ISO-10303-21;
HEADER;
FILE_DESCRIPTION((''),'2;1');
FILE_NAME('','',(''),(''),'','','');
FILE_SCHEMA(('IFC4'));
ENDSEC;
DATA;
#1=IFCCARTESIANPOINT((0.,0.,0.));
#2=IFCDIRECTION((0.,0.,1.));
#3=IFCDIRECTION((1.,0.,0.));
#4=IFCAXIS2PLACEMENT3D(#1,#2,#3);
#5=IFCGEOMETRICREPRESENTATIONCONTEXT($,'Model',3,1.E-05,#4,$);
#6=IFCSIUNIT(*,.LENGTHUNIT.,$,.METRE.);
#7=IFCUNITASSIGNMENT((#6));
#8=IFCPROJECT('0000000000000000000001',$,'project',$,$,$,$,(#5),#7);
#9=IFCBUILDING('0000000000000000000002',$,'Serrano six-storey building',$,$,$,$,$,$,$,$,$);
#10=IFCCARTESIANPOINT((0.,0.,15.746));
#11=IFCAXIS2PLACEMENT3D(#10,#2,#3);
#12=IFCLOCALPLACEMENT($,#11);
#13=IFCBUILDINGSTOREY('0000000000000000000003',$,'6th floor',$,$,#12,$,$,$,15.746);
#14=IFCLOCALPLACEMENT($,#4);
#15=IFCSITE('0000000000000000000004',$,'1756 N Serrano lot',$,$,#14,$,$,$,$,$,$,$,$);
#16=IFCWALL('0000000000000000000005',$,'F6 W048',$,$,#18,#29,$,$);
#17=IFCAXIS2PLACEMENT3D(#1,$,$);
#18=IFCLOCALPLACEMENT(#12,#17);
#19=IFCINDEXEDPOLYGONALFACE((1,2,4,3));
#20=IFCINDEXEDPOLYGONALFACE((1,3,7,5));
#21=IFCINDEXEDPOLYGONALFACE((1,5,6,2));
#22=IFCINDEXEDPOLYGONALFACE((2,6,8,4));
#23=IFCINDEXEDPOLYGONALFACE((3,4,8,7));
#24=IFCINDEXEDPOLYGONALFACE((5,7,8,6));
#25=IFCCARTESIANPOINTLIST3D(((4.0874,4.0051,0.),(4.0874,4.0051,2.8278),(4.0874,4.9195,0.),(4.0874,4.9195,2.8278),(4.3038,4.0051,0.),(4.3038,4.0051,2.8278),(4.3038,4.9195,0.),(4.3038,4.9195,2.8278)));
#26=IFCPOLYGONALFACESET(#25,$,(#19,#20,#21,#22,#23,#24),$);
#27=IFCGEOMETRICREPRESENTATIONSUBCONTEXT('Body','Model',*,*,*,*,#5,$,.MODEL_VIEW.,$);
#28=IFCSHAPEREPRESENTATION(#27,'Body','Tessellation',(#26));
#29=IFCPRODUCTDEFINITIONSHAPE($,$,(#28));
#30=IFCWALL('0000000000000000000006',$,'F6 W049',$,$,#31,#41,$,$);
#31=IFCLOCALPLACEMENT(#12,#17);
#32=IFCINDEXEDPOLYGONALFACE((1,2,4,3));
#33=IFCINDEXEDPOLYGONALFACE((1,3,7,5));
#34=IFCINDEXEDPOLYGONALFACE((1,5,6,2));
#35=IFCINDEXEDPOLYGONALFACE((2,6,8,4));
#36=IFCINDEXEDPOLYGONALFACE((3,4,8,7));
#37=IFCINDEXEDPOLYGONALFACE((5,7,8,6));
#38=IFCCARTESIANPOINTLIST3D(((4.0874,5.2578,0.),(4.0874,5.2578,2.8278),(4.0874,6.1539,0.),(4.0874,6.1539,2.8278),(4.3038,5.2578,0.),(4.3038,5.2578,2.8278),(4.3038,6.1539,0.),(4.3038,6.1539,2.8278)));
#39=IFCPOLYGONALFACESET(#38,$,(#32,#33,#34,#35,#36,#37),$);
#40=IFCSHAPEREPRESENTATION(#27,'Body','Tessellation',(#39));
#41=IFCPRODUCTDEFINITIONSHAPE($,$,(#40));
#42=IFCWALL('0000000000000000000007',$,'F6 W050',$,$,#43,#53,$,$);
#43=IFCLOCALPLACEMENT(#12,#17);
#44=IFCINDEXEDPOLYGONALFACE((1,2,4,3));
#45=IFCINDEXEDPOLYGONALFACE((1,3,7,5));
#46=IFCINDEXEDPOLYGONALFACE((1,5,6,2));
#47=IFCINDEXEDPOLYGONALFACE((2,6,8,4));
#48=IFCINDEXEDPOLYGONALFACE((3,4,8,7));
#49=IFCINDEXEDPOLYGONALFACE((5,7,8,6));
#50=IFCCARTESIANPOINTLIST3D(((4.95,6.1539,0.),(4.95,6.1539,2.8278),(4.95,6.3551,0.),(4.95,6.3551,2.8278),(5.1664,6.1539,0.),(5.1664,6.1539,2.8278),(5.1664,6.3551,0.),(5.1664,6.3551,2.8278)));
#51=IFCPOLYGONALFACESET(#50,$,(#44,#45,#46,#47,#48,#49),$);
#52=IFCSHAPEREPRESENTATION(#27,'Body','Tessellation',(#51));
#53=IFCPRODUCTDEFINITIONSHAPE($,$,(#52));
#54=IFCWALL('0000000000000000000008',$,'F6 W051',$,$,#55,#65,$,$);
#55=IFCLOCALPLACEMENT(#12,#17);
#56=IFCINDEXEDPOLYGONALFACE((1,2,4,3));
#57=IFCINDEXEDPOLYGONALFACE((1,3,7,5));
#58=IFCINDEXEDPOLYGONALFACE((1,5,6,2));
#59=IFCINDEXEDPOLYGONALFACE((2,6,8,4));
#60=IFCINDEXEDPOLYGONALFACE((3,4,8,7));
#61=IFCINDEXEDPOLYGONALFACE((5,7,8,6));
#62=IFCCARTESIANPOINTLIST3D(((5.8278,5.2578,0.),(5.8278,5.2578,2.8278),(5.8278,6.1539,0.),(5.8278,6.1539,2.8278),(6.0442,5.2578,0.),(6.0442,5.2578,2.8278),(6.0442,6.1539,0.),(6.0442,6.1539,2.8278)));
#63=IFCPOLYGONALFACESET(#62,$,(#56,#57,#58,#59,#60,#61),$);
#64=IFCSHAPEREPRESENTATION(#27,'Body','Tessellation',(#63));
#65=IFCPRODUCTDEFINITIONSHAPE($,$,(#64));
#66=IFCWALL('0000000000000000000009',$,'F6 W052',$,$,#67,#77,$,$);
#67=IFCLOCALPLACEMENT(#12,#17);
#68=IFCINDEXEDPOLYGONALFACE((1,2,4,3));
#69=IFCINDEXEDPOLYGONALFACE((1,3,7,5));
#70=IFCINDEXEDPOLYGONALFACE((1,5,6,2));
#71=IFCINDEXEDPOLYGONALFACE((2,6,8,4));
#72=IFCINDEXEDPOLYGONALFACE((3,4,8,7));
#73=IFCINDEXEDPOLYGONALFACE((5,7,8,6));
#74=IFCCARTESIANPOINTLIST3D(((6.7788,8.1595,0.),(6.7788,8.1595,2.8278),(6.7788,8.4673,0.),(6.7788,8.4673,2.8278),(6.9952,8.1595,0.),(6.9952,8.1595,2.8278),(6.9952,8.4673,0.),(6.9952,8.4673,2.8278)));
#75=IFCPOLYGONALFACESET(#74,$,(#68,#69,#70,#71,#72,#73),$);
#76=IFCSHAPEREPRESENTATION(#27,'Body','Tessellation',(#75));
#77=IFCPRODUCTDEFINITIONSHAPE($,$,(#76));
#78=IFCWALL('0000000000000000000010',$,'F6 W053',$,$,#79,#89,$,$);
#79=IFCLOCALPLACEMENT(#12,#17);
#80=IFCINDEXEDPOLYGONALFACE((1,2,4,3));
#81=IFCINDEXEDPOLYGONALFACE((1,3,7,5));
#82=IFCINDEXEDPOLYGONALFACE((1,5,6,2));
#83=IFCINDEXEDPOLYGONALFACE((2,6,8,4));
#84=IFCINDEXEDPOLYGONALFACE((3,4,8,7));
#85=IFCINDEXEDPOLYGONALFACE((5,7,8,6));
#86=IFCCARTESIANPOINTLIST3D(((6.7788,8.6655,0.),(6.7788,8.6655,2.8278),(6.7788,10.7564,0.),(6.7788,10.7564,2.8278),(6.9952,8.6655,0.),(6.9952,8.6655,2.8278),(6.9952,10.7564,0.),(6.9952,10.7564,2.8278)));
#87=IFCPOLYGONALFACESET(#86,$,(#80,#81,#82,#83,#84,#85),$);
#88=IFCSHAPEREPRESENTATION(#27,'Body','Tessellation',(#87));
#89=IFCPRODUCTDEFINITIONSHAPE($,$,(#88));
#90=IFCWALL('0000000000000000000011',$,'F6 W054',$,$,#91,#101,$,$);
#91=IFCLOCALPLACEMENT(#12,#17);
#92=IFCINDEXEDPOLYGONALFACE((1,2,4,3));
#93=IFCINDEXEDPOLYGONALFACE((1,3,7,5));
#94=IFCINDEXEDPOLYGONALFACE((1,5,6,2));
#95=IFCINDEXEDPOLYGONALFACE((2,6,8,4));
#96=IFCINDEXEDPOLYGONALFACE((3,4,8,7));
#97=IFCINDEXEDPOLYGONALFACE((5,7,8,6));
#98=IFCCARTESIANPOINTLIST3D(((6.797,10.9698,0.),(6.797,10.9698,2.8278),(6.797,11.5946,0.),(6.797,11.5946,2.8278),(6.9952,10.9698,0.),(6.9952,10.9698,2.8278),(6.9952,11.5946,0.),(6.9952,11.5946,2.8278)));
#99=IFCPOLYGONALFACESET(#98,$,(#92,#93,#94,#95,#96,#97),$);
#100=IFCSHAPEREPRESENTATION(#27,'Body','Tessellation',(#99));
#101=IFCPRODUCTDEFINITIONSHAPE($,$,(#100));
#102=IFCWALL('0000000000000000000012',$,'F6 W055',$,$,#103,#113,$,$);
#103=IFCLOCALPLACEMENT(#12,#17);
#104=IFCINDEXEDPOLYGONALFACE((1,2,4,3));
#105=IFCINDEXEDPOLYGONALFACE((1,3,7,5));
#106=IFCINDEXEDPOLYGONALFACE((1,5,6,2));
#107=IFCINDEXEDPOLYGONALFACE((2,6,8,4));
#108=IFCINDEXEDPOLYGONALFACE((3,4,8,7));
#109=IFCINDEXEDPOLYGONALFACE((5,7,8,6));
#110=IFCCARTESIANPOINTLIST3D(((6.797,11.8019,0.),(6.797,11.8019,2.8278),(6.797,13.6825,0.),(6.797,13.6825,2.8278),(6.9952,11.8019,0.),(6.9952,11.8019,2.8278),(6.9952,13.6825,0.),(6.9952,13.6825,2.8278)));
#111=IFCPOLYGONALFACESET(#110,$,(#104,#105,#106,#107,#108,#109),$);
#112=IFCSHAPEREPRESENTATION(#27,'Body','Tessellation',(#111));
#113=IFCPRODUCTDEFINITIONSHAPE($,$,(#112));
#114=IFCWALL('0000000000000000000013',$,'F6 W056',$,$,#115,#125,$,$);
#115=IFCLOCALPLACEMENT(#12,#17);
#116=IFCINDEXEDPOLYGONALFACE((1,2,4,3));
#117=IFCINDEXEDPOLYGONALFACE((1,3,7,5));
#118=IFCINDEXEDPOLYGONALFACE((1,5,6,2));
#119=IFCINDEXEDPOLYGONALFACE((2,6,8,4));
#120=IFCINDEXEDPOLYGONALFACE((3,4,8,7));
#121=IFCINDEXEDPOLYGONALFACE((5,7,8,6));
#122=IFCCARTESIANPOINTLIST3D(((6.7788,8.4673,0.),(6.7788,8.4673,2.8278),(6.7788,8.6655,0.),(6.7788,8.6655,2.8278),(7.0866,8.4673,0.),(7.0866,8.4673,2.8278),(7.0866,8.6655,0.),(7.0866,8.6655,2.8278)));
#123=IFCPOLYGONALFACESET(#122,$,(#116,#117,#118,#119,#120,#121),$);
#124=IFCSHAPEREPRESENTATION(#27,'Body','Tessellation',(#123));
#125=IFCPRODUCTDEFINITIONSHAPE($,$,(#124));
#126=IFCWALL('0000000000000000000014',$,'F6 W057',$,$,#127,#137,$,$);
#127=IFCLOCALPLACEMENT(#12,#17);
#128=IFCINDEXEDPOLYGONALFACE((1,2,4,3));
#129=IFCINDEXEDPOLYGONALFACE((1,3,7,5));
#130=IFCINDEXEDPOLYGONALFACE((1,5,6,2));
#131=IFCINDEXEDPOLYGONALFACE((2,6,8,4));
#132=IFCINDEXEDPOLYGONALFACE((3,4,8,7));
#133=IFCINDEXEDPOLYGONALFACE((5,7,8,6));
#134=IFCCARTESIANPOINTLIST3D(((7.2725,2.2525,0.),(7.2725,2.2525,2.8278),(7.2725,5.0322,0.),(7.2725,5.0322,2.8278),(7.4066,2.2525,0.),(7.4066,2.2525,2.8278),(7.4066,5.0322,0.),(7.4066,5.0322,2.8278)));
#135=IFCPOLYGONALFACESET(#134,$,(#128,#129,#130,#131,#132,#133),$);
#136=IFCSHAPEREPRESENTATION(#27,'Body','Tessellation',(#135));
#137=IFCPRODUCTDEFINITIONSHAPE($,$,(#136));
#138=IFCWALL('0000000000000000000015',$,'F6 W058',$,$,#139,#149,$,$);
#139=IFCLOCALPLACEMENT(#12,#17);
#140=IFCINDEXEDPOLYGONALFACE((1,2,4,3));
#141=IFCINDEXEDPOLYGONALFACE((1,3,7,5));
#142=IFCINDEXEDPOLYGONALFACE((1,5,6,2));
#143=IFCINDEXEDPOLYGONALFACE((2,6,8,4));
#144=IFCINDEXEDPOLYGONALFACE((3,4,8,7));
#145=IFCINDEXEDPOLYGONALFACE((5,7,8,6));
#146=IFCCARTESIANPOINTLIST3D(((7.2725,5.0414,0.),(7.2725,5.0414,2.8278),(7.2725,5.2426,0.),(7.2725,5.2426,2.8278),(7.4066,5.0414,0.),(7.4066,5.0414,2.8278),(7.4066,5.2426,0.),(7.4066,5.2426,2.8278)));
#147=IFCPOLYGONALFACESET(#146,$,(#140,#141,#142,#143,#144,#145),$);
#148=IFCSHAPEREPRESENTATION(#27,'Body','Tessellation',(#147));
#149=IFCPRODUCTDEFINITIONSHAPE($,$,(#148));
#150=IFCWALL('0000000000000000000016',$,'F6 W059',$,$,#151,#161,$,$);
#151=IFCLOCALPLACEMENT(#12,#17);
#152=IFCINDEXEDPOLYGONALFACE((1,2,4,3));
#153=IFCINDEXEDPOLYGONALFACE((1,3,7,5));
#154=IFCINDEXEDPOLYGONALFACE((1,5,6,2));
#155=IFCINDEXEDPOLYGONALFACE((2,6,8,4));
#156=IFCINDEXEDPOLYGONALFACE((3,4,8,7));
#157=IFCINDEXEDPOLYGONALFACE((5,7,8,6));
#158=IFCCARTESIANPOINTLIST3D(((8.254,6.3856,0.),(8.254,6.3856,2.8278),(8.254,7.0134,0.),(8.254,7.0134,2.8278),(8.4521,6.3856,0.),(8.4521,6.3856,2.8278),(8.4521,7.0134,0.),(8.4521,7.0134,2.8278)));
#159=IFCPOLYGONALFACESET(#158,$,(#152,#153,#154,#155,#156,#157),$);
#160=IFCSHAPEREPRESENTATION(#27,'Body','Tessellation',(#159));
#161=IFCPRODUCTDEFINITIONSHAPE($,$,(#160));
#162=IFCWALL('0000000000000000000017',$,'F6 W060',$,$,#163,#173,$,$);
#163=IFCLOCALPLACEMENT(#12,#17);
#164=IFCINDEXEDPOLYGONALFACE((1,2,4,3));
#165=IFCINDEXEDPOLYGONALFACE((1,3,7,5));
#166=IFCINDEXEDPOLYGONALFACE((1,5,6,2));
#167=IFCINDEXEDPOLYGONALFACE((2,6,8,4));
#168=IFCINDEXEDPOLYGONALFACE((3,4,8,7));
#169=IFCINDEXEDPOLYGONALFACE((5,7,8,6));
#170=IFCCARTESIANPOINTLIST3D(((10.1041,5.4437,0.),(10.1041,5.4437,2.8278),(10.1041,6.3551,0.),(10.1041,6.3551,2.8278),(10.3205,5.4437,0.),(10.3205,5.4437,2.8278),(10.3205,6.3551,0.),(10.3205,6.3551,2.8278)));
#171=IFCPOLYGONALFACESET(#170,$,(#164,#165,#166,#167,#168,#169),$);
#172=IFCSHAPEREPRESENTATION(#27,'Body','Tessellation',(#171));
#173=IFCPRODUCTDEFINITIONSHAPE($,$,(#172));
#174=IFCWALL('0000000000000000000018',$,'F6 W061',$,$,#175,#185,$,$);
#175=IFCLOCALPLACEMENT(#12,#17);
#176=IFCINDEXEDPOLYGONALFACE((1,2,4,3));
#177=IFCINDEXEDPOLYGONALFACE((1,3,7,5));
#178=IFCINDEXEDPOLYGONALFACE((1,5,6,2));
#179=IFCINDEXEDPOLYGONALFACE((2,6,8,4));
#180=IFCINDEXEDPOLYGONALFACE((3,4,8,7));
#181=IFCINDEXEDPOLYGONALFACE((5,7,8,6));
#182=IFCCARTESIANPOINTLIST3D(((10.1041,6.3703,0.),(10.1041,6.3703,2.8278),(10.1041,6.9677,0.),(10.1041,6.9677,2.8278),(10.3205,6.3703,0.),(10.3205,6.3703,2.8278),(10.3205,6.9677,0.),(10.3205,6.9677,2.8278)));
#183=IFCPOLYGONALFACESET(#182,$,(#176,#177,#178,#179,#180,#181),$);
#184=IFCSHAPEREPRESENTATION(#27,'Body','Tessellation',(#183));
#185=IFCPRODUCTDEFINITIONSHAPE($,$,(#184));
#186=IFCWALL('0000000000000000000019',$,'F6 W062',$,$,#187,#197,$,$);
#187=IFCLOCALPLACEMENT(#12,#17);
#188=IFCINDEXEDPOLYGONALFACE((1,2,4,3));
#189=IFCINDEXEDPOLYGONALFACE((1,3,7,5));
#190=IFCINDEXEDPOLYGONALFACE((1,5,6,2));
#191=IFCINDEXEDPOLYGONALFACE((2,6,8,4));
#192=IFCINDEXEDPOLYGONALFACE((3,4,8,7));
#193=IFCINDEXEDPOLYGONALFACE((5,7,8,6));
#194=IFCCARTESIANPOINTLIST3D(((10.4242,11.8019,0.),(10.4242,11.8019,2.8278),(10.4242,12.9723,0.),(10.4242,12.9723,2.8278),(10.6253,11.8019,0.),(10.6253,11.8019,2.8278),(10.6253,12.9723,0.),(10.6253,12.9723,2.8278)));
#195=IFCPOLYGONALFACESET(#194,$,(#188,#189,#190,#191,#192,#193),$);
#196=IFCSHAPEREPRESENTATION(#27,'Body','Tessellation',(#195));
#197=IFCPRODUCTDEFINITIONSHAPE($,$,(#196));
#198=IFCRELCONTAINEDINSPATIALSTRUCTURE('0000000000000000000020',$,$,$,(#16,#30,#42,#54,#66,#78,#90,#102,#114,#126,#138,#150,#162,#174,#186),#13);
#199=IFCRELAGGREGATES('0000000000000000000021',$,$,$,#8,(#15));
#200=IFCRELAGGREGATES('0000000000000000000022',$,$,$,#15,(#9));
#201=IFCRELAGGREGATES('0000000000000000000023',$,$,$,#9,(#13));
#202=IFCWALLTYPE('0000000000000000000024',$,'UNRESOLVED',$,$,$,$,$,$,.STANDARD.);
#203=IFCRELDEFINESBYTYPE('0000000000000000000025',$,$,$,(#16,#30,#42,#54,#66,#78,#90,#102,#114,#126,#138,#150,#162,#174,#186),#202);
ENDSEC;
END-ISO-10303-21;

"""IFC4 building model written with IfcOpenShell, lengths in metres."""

from ifc_helpers import new_model, si_unit, frame, origin_with_axes, place, context, subcontext, project, spatial, polyline, outline, extrude, type_object, element, save


model = new_model("IFC4")

# Units and contexts
model_context = context("Model", 3, precision=1e-05, world=origin_with_axes())
body_context = subcontext(model_context, "Body", "Model", "MODEL_VIEW")
ifc_project = project(units=[si_unit("LENGTHUNIT", "METRE")], contexts=[model_context])

# Site, building, storey
site_placement = place(None, origin_with_axes())
site = spatial("IfcSite", under=ifc_project, at=site_placement, Name="1756 N Serrano lot")
building = spatial("IfcBuilding", under=site, Name="Serrano six-storey building")
storey_placement = place(None, frame((0.0, 0.0, 15.746), z_axis=(0.0, 0.0, 1.0), x_axis=(1.0, 0.0, 0.0)))
storey = spatial("IfcBuildingStorey", under=building, at=storey_placement, Name="6th floor", Elevation=15.746)

# Walls
wall_type = type_object("IfcWallType", Name="UNRESOLVED", PredefinedType="STANDARD")
wall_1_placement = place(storey_placement, frame((0.0, 0.0, -15.746), z_axis=(0.0, 0.0, 1.0), x_axis=(1.0, 0.0, 0.0)))
element("IfcWall", 1, at=wall_1_placement, inside=storey, type_object=wall_type, Name="F6 W048", context=body_context, shape_type="SweptSolid", body=[
    extrude(outline(polyline([(4.0874, 4.9195), (4.3038, 4.9195), (4.3038, 4.0051), (4.0874, 4.0051), (4.0874, 4.9195)])), frame((0.0, 0.0, 15.746)), (0.0, 0.0, 1.0), 2.8278),
])
wall_2_placement = place(storey_placement, frame((0.0, 0.0, -15.746), z_axis=(0.0, 0.0, 1.0), x_axis=(1.0, 0.0, 0.0)))
element("IfcWall", 2, at=wall_2_placement, inside=storey, type_object=wall_type, Name="F6 W049", context=body_context, shape_type="SweptSolid", body=[
    extrude(outline(polyline([(4.0874, 6.1539), (4.3038, 6.1539), (4.3038, 5.2578), (4.0874, 5.2578), (4.0874, 6.1539)])), frame((0.0, 0.0, 15.746)), (0.0, 0.0, 1.0), 2.8278),
])
wall_3_placement = place(storey_placement, frame((0.0, 0.0, -15.746), z_axis=(0.0, 0.0, 1.0), x_axis=(1.0, 0.0, 0.0)))
element("IfcWall", 3, at=wall_3_placement, inside=storey, type_object=wall_type, Name="F6 W050", context=body_context, shape_type="SweptSolid", body=[
    extrude(outline(polyline([(4.95, 6.3551), (5.1664, 6.3551), (5.1664, 6.1539), (4.95, 6.1539), (4.95, 6.3551)])), frame((0.0, 0.0, 15.746)), (0.0, 0.0, 1.0), 2.8278),
])
wall_4_placement = place(storey_placement, frame((0.0, 0.0, -15.746), z_axis=(0.0, 0.0, 1.0), x_axis=(1.0, 0.0, 0.0)))
element("IfcWall", 4, at=wall_4_placement, inside=storey, type_object=wall_type, Name="F6 W051", context=body_context, shape_type="SweptSolid", body=[
    extrude(outline(polyline([(5.8278, 6.1539), (6.0442, 6.1539), (6.0442, 5.2578), (5.8278, 5.2578), (5.8278, 6.1539)])), frame((0.0, 0.0, 15.746)), (0.0, 0.0, 1.0), 2.8278),
])
wall_5_placement = place(storey_placement, frame((0.0, 0.0, -15.746), z_axis=(0.0, 0.0, 1.0), x_axis=(1.0, 0.0, 0.0)))
element("IfcWall", 5, at=wall_5_placement, inside=storey, type_object=wall_type, Name="F6 W052", context=body_context, shape_type="SweptSolid", body=[
    extrude(outline(polyline([(6.7788, 8.4673), (6.9952, 8.4673), (6.9952, 8.1595), (6.7788, 8.1595), (6.7788, 8.4673)])), frame((0.0, 0.0, 15.746)), (0.0, 0.0, 1.0), 2.8278),
])
wall_6_placement = place(storey_placement, frame((0.0, 0.0, -15.746), z_axis=(0.0, 0.0, 1.0), x_axis=(1.0, 0.0, 0.0)))
element("IfcWall", 6, at=wall_6_placement, inside=storey, type_object=wall_type, Name="F6 W053", context=body_context, shape_type="SweptSolid", body=[
    extrude(outline(polyline([(6.7788, 10.7564), (6.9952, 10.7564), (6.9952, 8.6655), (6.7788, 8.6655), (6.7788, 10.7564)])), frame((0.0, 0.0, 15.746)), (0.0, 0.0, 1.0), 2.8278),
])
wall_7_placement = place(storey_placement, frame((0.0, 0.0, -15.746), z_axis=(0.0, 0.0, 1.0), x_axis=(1.0, 0.0, 0.0)))
element("IfcWall", 7, at=wall_7_placement, inside=storey, type_object=wall_type, Name="F6 W054", context=body_context, shape_type="SweptSolid", body=[
    extrude(outline(polyline([(6.797, 11.5946), (6.9952, 11.5946), (6.9952, 10.9698), (6.797, 10.9698), (6.797, 11.5946)])), frame((0.0, 0.0, 15.746)), (0.0, 0.0, 1.0), 2.8278),
])
wall_8_placement = place(storey_placement, frame((0.0, 0.0, -15.746), z_axis=(0.0, 0.0, 1.0), x_axis=(1.0, 0.0, 0.0)))
element("IfcWall", 8, at=wall_8_placement, inside=storey, type_object=wall_type, Name="F6 W055", context=body_context, shape_type="SweptSolid", body=[
    extrude(outline(polyline([(6.797, 13.6825), (6.9952, 13.6825), (6.9952, 11.8019), (6.797, 11.8019), (6.797, 13.6825)])), frame((0.0, 0.0, 15.746)), (0.0, 0.0, 1.0), 2.8278),
])
wall_9_placement = place(storey_placement, frame((0.0, 0.0, -15.746), z_axis=(0.0, 0.0, 1.0), x_axis=(1.0, 0.0, 0.0)))
element("IfcWall", 9, at=wall_9_placement, inside=storey, type_object=wall_type, Name="F6 W056", context=body_context, shape_type="SweptSolid", body=[
    extrude(outline(polyline([(6.7788, 8.6655), (7.0866, 8.6655), (7.0866, 8.4673), (6.7788, 8.4673), (6.7788, 8.6655)])), frame((0.0, 0.0, 15.746)), (0.0, 0.0, 1.0), 2.8278),
])
wall_10_placement = place(storey_placement, frame((0.0, 0.0, -15.746), z_axis=(0.0, 0.0, 1.0), x_axis=(1.0, 0.0, 0.0)))
element("IfcWall", 10, at=wall_10_placement, inside=storey, type_object=wall_type, Name="F6 W057", context=body_context, shape_type="SweptSolid", body=[
    extrude(outline(polyline([(7.2725, 5.0322), (7.4066, 5.0322), (7.4066, 2.2525), (7.2725, 2.2525), (7.2725, 5.0322)])), frame((0.0, 0.0, 15.746)), (0.0, 0.0, 1.0), 2.8278),
])
wall_11_placement = place(storey_placement, frame((0.0, 0.0, -15.746), z_axis=(0.0, 0.0, 1.0), x_axis=(1.0, 0.0, 0.0)))
element("IfcWall", 11, at=wall_11_placement, inside=storey, type_object=wall_type, Name="F6 W058", context=body_context, shape_type="SweptSolid", body=[
    extrude(outline(polyline([(7.2725, 5.2426), (7.4066, 5.2426), (7.4066, 5.0414), (7.2725, 5.0414), (7.2725, 5.2426)])), frame((0.0, 0.0, 15.746)), (0.0, 0.0, 1.0), 2.8278),
])
wall_12_placement = place(storey_placement, frame((0.0, 0.0, -15.746), z_axis=(0.0, 0.0, 1.0), x_axis=(1.0, 0.0, 0.0)))
element("IfcWall", 12, at=wall_12_placement, inside=storey, type_object=wall_type, Name="F6 W059", context=body_context, shape_type="SweptSolid", body=[
    extrude(outline(polyline([(8.254, 7.0134), (8.4521, 7.0134), (8.4521, 6.3856), (8.254, 6.3856), (8.254, 7.0134)])), frame((0.0, 0.0, 15.746)), (0.0, 0.0, 1.0), 2.8278),
])
wall_13_placement = place(storey_placement, frame((0.0, 0.0, -15.746), z_axis=(0.0, 0.0, 1.0), x_axis=(1.0, 0.0, 0.0)))
element("IfcWall", 13, at=wall_13_placement, inside=storey, type_object=wall_type, Name="F6 W060", context=body_context, shape_type="SweptSolid", body=[
    extrude(outline(polyline([(10.1041, 6.3551), (10.3205, 6.3551), (10.3205, 5.4437), (10.1041, 5.4437), (10.1041, 6.3551)])), frame((0.0, 0.0, 15.746)), (0.0, 0.0, 1.0), 2.8278),
])
wall_14_placement = place(storey_placement, frame((0.0, 0.0, -15.746), z_axis=(0.0, 0.0, 1.0), x_axis=(1.0, 0.0, 0.0)))
element("IfcWall", 14, at=wall_14_placement, inside=storey, type_object=wall_type, Name="F6 W061", context=body_context, shape_type="SweptSolid", body=[
    extrude(outline(polyline([(10.1041, 6.9677), (10.3205, 6.9677), (10.3205, 6.3703), (10.1041, 6.3703), (10.1041, 6.9677)])), frame((0.0, 0.0, 15.746)), (0.0, 0.0, 1.0), 2.8278),
])
wall_15_placement = place(storey_placement, frame((0.0, 0.0, -15.746), z_axis=(0.0, 0.0, 1.0), x_axis=(1.0, 0.0, 0.0)))
element("IfcWall", 15, at=wall_15_placement, inside=storey, type_object=wall_type, Name="F6 W062", context=body_context, shape_type="SweptSolid", body=[
    extrude(outline(polyline([(10.4242, 12.9723), (10.6253, 12.9723), (10.6253, 11.8019), (10.4242, 11.8019), (10.4242, 12.9723)])), frame((0.0, 0.0, 15.746)), (0.0, 0.0, 1.0), 2.8278),
])

save(model, "model.ifc")
